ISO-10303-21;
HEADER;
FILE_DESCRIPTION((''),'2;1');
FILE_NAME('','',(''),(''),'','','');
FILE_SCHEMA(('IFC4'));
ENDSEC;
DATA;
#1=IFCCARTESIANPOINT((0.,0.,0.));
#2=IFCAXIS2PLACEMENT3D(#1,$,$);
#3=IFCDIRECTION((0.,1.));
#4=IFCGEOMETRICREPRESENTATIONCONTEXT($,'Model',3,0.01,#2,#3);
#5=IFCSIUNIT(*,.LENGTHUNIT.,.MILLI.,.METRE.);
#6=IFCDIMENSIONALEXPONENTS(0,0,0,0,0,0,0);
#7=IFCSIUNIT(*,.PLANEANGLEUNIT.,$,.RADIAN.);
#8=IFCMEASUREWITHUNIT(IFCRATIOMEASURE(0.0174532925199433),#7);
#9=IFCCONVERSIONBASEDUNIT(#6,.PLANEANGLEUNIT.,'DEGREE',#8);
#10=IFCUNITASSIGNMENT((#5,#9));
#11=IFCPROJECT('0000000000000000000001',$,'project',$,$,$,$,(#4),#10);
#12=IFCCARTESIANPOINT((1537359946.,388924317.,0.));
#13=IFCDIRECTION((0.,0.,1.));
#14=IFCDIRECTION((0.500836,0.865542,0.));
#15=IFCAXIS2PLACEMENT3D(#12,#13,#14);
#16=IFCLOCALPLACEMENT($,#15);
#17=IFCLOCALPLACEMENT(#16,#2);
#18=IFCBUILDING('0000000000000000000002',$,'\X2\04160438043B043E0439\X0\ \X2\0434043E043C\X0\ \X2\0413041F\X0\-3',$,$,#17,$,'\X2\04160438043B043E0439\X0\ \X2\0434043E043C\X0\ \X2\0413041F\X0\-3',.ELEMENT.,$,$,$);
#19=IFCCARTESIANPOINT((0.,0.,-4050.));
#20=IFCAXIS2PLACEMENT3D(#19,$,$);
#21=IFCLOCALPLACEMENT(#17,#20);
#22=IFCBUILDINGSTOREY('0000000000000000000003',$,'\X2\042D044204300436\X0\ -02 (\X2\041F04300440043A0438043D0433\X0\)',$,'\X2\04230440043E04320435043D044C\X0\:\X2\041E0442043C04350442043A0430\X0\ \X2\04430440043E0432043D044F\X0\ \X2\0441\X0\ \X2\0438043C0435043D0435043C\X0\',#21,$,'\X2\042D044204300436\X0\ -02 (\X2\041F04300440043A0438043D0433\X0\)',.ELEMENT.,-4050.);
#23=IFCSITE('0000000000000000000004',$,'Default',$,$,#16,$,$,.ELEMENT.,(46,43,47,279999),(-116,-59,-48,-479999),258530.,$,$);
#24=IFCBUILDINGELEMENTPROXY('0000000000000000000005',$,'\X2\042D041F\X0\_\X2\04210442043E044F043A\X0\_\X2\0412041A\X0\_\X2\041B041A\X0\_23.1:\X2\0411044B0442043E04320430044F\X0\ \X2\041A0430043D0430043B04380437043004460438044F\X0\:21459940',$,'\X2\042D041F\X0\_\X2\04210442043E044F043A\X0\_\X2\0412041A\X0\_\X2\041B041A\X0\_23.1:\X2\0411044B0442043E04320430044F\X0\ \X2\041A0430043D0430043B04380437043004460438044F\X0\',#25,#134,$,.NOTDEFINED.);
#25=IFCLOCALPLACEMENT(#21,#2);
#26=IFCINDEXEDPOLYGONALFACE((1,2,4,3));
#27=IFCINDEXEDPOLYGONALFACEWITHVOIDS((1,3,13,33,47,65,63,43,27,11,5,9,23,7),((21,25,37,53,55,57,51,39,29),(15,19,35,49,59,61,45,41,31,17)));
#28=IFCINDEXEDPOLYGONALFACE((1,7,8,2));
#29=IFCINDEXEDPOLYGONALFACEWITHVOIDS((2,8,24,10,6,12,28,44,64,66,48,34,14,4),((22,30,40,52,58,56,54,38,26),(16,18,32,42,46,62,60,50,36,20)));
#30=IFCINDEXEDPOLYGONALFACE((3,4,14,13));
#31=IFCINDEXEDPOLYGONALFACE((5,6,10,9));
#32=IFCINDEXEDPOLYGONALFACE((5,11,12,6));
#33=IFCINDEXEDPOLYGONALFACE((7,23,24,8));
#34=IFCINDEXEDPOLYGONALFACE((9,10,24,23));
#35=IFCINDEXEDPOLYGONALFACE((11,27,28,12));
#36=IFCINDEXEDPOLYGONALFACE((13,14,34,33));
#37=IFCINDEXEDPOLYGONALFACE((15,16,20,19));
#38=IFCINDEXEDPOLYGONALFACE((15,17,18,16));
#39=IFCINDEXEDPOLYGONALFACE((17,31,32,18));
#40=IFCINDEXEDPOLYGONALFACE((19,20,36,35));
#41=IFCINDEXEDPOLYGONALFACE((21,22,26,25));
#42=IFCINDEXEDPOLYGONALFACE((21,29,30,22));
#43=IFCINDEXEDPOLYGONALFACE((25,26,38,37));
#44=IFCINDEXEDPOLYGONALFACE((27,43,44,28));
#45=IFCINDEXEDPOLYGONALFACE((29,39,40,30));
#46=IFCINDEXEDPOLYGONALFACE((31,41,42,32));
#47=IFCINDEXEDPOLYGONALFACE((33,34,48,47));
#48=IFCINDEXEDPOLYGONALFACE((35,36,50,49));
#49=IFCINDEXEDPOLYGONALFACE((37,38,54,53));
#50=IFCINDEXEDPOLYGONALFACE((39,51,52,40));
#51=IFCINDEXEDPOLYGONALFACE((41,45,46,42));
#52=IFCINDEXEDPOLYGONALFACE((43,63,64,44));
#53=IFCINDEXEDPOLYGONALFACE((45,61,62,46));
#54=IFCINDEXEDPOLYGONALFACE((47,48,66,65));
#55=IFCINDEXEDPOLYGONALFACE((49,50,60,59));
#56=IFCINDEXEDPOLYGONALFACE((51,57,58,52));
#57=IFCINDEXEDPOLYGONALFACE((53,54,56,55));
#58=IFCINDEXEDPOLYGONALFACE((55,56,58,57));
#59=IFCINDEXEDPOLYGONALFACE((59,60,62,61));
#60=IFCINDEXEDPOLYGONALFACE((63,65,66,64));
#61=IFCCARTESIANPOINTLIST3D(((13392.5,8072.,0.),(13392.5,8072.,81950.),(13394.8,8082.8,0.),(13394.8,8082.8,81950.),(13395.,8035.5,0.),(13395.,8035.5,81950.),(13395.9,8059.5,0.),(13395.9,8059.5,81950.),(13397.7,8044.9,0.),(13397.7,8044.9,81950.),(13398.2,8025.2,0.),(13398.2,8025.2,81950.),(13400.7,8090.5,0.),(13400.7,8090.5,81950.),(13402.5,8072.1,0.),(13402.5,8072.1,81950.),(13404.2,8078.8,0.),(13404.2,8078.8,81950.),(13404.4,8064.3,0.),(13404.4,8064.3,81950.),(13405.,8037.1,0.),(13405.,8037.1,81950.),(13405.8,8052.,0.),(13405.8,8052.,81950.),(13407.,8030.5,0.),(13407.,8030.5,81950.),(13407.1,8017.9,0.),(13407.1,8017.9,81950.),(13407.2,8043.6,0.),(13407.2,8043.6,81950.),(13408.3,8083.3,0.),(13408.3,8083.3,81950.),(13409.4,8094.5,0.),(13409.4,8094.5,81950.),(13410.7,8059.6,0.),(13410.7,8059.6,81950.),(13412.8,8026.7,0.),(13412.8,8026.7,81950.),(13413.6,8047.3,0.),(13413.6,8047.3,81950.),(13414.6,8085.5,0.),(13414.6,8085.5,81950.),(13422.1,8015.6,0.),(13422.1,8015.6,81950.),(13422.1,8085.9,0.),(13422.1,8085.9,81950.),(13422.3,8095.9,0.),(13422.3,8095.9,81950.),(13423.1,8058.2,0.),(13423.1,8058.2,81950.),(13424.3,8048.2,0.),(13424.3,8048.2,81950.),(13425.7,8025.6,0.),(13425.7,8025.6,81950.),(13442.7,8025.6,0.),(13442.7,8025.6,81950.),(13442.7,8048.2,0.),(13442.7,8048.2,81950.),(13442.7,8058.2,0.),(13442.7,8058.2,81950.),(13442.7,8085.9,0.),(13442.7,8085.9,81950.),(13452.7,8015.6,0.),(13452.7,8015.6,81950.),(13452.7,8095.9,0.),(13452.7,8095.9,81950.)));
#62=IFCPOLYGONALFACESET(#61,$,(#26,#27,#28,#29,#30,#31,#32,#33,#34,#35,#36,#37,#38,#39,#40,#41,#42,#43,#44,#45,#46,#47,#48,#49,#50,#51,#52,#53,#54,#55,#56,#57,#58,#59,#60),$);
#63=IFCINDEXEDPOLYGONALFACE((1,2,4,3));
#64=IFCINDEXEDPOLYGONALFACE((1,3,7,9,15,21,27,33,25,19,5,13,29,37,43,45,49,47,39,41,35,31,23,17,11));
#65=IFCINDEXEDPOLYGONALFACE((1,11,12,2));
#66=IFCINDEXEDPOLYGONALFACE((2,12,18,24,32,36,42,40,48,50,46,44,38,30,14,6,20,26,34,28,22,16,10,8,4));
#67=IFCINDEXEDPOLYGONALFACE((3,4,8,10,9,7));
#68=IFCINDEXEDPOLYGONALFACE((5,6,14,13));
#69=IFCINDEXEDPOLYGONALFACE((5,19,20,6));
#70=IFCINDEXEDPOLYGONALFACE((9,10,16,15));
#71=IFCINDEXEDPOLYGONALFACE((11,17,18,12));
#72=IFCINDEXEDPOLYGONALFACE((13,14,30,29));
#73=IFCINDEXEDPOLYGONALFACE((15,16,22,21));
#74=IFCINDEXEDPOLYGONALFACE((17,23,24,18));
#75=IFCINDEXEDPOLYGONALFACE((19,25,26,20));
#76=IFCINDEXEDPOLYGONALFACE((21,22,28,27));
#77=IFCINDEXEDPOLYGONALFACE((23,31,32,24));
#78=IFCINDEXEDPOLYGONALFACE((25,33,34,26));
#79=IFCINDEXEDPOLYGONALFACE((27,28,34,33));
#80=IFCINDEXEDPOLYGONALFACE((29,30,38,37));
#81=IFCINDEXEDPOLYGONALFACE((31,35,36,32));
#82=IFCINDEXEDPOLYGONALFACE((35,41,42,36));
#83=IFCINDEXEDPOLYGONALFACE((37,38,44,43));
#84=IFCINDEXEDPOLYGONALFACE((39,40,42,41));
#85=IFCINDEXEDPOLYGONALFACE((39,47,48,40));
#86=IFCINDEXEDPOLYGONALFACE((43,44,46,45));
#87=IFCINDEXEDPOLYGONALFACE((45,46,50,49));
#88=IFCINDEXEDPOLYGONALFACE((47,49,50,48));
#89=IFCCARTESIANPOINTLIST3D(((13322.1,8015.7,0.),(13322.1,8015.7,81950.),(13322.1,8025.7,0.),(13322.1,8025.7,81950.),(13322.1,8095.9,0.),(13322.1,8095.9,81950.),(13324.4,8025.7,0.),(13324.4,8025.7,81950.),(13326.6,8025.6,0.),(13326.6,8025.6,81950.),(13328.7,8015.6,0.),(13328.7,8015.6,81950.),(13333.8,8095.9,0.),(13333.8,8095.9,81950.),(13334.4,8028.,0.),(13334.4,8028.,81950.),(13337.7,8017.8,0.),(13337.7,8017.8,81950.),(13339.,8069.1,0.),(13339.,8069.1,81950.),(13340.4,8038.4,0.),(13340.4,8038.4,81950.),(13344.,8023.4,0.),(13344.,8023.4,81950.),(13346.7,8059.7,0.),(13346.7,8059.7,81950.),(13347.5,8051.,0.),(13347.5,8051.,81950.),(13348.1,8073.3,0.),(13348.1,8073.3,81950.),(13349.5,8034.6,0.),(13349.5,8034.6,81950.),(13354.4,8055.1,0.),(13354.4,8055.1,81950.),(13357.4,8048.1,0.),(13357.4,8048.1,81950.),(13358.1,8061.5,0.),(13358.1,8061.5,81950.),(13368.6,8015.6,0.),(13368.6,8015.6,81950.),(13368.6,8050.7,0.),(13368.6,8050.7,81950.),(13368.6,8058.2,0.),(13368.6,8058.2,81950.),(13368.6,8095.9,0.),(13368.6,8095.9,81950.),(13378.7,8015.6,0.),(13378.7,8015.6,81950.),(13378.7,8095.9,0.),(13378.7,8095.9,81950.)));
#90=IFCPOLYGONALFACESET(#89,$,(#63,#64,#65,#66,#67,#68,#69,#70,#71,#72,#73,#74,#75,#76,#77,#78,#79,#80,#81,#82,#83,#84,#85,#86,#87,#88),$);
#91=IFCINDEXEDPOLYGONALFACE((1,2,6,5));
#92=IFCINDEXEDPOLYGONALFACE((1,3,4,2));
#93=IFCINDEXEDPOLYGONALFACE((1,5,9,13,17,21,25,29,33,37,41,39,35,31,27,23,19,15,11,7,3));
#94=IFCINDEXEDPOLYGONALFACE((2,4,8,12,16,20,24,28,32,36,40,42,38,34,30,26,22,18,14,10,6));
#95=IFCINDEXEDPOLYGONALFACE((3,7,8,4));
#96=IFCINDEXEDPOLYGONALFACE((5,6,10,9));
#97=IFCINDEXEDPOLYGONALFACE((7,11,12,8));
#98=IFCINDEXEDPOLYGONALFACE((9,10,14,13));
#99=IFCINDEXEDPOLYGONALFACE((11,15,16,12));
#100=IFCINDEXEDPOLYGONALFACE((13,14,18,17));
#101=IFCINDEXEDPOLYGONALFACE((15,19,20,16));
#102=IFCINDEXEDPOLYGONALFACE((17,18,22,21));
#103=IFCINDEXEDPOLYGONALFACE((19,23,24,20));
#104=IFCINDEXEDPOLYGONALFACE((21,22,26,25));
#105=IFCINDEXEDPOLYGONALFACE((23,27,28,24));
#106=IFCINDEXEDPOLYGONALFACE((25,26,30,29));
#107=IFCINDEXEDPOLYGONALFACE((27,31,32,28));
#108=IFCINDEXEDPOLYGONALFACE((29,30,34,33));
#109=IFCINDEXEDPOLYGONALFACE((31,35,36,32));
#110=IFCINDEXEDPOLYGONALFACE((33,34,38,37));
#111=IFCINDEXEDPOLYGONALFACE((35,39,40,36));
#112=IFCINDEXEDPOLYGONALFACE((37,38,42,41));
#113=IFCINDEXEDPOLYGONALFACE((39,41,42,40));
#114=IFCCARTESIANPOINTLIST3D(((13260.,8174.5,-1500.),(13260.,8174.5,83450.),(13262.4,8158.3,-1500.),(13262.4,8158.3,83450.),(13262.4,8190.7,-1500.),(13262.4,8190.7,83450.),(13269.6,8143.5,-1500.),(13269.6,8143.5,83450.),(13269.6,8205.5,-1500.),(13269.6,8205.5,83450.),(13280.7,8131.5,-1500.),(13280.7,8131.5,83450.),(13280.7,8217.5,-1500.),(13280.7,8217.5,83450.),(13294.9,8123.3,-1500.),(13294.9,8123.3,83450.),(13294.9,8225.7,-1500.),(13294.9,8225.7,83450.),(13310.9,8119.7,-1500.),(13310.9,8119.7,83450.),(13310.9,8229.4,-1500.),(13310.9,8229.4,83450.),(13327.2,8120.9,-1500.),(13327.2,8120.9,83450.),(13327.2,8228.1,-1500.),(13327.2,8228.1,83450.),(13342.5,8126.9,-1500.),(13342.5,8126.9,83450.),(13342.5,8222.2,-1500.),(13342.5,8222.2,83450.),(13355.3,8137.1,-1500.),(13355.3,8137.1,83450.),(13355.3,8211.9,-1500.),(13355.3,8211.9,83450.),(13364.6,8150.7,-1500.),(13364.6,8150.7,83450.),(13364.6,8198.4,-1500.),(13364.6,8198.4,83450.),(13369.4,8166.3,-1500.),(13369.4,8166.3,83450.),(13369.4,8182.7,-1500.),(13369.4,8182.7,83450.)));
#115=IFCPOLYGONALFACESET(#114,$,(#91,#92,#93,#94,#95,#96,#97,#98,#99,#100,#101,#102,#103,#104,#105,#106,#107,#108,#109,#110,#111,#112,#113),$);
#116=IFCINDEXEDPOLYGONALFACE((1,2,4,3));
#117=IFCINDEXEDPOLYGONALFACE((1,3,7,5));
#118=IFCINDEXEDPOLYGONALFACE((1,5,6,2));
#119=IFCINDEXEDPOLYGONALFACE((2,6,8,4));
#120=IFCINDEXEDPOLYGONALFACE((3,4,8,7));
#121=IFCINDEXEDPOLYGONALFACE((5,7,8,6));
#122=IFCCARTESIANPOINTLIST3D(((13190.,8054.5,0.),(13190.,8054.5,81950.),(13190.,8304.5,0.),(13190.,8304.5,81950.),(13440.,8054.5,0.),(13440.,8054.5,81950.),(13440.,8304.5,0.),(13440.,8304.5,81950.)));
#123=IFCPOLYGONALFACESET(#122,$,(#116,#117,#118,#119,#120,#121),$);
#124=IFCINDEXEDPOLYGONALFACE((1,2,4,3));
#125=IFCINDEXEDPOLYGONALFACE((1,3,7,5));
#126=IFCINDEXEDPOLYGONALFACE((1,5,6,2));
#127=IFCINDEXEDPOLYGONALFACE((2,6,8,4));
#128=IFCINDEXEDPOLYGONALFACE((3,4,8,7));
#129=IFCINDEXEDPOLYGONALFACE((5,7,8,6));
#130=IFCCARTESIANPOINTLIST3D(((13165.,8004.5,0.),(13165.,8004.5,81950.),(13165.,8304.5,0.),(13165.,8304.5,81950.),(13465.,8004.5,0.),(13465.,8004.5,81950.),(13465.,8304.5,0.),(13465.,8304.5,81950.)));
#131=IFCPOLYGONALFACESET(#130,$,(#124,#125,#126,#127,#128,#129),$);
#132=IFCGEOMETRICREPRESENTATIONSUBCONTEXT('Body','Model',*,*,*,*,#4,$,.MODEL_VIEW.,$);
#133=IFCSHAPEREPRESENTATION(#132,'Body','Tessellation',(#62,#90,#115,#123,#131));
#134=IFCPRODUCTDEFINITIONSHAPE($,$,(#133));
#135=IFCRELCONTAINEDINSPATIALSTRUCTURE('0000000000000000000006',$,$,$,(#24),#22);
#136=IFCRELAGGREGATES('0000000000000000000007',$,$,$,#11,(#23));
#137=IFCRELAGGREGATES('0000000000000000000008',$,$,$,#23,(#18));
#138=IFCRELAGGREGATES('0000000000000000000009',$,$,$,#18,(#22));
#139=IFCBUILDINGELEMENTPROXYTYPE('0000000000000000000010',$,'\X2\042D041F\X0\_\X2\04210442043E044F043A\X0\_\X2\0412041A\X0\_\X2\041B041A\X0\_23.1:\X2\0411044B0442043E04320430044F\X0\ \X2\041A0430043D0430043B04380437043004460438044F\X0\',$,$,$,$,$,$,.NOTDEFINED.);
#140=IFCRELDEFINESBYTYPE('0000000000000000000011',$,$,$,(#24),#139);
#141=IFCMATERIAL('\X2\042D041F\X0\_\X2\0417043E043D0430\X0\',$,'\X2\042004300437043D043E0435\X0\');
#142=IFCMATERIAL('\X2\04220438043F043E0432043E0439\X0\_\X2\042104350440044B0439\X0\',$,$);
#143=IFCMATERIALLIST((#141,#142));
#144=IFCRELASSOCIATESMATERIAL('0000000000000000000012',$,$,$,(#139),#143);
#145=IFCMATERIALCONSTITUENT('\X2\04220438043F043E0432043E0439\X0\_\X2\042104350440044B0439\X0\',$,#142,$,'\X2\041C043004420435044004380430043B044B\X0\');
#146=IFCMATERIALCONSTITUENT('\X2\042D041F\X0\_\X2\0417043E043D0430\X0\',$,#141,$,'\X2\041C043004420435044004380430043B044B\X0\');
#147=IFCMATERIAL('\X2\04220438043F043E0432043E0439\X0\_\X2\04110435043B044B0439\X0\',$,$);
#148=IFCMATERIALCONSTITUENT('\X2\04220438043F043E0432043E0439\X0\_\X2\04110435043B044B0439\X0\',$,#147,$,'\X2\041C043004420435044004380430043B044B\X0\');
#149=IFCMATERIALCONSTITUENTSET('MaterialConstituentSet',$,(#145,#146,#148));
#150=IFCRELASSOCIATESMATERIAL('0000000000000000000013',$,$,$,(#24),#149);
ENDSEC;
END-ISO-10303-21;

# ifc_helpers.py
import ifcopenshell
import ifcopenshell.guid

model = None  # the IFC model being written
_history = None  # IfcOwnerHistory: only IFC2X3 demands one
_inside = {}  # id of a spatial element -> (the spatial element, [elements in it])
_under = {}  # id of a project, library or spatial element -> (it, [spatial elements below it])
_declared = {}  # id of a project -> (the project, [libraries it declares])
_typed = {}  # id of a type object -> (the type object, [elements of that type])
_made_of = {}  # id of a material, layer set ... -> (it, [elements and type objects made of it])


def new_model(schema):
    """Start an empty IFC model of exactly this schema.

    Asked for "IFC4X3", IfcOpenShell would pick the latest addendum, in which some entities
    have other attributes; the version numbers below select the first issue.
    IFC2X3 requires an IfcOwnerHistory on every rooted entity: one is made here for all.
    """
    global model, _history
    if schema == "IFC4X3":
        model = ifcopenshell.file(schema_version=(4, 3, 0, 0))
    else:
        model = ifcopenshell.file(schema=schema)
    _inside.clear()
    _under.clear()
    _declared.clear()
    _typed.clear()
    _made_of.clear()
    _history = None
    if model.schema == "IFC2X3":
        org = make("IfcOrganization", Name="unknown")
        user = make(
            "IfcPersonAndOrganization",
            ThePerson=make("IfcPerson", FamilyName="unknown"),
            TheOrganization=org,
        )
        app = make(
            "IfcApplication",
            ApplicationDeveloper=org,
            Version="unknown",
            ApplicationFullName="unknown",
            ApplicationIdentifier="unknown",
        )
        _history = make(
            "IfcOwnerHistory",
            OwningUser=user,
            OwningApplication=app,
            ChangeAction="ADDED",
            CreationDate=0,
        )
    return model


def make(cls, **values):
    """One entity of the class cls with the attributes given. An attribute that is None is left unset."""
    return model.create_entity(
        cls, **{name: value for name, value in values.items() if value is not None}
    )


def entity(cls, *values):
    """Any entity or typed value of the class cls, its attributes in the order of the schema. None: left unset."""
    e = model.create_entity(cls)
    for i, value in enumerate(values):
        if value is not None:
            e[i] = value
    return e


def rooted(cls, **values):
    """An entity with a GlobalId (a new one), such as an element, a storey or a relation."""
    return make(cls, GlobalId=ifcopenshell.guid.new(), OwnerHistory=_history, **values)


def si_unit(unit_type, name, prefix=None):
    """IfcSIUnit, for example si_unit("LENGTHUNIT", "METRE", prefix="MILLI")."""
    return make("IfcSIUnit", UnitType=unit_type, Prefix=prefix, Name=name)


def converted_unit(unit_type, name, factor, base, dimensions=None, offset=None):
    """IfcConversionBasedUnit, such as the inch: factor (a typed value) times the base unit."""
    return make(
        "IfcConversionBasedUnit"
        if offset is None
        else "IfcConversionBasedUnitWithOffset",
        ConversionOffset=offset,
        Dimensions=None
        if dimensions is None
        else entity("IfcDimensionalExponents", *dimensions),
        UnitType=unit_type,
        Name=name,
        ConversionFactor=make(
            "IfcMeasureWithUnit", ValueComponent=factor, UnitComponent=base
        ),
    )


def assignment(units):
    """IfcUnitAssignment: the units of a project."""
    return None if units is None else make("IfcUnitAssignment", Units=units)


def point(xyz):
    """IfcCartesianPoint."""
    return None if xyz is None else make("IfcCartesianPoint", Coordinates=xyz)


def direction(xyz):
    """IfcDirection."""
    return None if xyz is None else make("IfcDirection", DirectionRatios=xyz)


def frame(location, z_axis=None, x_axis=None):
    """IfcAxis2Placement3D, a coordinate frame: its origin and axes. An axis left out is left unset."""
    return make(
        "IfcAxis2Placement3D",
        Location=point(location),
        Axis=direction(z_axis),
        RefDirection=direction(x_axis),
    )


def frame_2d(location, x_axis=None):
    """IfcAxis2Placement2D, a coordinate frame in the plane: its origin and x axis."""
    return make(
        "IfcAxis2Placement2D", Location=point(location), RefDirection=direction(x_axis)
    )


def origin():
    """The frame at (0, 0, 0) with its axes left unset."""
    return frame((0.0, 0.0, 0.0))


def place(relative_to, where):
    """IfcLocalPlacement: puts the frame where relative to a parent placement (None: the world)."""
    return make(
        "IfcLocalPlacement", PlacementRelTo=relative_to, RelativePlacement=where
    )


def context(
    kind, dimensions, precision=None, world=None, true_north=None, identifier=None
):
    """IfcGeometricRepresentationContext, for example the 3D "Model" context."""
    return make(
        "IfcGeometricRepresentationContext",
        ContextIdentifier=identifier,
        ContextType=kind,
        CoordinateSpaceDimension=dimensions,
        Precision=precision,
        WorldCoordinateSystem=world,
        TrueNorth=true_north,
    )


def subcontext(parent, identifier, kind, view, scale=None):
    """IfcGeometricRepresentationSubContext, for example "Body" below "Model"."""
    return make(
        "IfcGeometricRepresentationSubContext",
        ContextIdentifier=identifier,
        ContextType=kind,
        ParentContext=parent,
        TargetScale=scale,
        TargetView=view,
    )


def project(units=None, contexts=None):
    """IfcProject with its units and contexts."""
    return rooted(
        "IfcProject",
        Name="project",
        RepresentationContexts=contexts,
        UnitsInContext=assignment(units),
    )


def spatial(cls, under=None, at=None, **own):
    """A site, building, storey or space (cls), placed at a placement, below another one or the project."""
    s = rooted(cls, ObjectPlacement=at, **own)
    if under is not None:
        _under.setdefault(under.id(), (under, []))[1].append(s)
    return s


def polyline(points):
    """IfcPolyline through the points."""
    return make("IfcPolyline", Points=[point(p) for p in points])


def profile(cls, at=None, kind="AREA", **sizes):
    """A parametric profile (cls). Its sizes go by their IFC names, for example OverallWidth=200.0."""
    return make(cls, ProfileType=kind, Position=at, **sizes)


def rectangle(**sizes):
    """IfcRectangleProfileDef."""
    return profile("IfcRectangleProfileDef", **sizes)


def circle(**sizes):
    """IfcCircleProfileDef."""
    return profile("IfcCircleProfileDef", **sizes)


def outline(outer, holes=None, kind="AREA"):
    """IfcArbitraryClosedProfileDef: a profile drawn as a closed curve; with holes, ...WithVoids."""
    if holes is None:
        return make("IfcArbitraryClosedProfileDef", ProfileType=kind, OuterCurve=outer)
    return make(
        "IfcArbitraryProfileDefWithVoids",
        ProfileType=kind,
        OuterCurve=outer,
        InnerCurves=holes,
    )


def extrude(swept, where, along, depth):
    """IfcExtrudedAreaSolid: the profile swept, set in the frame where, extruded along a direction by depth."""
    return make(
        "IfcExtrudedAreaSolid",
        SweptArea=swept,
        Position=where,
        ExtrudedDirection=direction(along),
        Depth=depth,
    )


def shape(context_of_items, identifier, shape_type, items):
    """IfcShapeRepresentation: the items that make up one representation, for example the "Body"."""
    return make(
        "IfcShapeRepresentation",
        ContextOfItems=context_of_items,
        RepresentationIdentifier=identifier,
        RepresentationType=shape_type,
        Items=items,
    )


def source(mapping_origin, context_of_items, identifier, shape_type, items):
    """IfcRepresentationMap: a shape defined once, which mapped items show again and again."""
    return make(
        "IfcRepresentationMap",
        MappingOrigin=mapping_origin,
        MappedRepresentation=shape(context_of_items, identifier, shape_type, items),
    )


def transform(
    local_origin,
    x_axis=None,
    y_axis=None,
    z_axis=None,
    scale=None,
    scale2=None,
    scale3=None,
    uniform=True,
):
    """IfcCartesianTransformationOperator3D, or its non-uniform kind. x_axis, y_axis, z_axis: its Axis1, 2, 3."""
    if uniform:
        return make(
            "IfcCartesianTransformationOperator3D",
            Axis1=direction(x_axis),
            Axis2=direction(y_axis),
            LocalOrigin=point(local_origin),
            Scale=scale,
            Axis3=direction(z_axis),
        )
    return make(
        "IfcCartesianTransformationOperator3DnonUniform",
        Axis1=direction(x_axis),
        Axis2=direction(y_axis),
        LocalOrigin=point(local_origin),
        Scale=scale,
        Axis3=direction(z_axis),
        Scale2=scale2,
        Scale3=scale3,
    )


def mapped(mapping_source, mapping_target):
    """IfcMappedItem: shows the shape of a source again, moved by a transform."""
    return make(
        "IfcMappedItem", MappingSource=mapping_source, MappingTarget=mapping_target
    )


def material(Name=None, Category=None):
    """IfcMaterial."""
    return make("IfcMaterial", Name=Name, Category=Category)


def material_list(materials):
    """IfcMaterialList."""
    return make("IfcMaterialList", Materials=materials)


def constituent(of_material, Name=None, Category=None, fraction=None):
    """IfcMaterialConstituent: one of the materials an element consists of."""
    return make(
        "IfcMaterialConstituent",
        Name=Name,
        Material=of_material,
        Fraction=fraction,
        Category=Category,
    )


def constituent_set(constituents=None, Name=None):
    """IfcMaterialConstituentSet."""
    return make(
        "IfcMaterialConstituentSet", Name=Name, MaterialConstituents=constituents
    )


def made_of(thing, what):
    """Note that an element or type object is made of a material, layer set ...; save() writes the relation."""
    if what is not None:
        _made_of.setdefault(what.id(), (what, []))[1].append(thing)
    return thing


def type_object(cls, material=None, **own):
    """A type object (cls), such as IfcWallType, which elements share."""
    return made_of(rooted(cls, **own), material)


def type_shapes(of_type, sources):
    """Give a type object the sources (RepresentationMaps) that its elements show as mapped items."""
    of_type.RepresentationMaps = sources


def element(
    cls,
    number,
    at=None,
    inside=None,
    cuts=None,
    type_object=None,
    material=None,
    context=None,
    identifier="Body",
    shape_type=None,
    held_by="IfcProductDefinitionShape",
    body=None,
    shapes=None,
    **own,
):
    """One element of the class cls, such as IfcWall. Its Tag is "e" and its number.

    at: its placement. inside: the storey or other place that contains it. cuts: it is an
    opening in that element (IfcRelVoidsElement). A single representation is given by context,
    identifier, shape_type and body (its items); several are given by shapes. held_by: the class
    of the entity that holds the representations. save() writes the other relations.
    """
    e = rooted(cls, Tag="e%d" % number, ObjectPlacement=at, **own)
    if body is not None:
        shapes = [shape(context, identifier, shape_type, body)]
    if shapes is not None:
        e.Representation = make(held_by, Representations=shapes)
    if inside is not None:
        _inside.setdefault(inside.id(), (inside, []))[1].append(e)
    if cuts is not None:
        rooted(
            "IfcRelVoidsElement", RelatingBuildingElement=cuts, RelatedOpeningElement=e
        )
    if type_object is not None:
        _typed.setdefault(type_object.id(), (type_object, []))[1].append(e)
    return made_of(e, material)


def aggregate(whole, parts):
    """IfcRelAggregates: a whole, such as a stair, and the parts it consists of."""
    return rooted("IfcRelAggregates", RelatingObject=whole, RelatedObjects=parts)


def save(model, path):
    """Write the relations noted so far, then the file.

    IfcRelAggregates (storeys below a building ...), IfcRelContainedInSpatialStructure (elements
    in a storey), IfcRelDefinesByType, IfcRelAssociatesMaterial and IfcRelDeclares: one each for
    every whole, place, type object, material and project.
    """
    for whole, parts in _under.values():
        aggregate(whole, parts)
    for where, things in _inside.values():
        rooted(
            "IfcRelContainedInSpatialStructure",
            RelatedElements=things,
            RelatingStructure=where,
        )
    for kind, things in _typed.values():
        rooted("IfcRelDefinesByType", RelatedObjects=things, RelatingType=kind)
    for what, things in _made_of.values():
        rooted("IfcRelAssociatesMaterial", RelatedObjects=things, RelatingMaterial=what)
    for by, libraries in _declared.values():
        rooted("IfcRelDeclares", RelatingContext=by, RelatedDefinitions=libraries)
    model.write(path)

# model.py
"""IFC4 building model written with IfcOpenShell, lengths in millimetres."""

from ifc_helpers import new_model, entity, si_unit, converted_unit, direction, frame, frame_2d, origin, place, context, subcontext, project, spatial, polyline, rectangle, circle, outline, extrude, source, transform, mapped, material, material_list, constituent, constituent_set, type_object, type_shapes, element, save


model = new_model("IFC4")

# Units and contexts
model_context = context("Model", 3, precision=0.01, world=origin(), true_north=direction((0.0, 1.0)))
body_context = subcontext(model_context, "Body", "Model", "MODEL_VIEW")
ifc_project = project(units=[si_unit("LENGTHUNIT", "METRE", prefix="MILLI"), converted_unit("PLANEANGLEUNIT", "DEGREE", entity("IfcRatioMeasure", 0.0174532925199433), si_unit("PLANEANGLEUNIT", "RADIAN"), dimensions=[0, 0, 0, 0, 0, 0, 0])], contexts=[model_context])

# Site, building, storey
site_placement = place(None, frame((1537359946.0, 388924317.0, 0.0), z_axis=(0.0, 0.0, 1.0), x_axis=(0.500836, 0.865542, 0.0)))
site = spatial("IfcSite", under=ifc_project, at=site_placement, Name="Default", CompositionType="ELEMENT", RefLatitude=(46, 43, 47, 279999), RefLongitude=(-116, -59, -48, -479999), RefElevation=258530.0)
building_placement = place(site_placement, origin())
building = spatial("IfcBuilding", under=site, at=building_placement, Name="Жилой дом ГП-3", LongName="Жилой дом ГП-3", CompositionType="ELEMENT")
storey_placement = place(building_placement, frame((0.0, 0.0, -4050.0)))
storey = spatial("IfcBuildingStorey", under=building, at=storey_placement, Name="Этаж -02 (Паркинг)", ObjectType="Уровень:Отметка уровня с именем", LongName="Этаж -02 (Паркинг)", CompositionType="ELEMENT", Elevation=-4050.0)

# Building element proxy
ifc_material_1 = material(Name="Типовой_Серый")
ifc_constituent_1 = constituent(ifc_material_1, Name="Типовой_Серый", Category="Материалы")
ifc_material_2 = material(Name="ЭП_Зона", Category="Разное")
ifc_constituent_2 = constituent(ifc_material_2, Name="ЭП_Зона", Category="Материалы")
ifc_material_3 = material(Name="Типовой_Белый")
ifc_constituent_3 = constituent(ifc_material_3, Name="Типовой_Белый", Category="Материалы")
ifc_constituent_set_1 = constituent_set(constituents=[ifc_constituent_1, ifc_constituent_2, ifc_constituent_3], Name="MaterialConstituentSet")
ifc_material_list_1 = material_list([ifc_material_2, ifc_material_1])
building_element_proxy_type_1 = type_object("IfcBuildingElementProxyType", Name="ЭП_Стояк_ВК_ЛК_23.1:Бытовая Канализация", PredefinedType="NOTDEFINED", material=ifc_material_list_1)
shared_shape_1 = source(origin(), body_context, "Body", "SweptSolid", [
    extrude(outline(polyline([(-42.2, -39.0), (-11.8, -39.0), (1.1, -37.6), (9.8, -33.5), (15.7, -25.8), (18.0, -15.0), (14.6, -2.5), (4.7, 5.0), (12.8, 12.1), (15.5, 21.5), (12.3, 31.8), (3.4, 39.0), (-11.6, 41.4), (-42.2, 41.4), (-42.2, -39.0)]), holes=[polyline([(-32.2, 8.8), (-32.2, 31.4), (-15.2, 31.4), (-2.3, 30.3), (3.5, 26.4), (5.5, 19.9), (3.3, 13.3), (-3.1, 9.6), (-13.9, 8.8), (-32.2, 8.8)]), polyline([(-32.2, -28.9), (-32.2, -1.3), (-12.6, -1.3), (-0.2, -2.6), (6.1, -7.3), (8.0, -15.1), (6.3, -21.9), (2.2, -26.3), (-4.1, -28.5), (-11.6, -28.9), (-32.2, -28.9)])]), frame((54.5, -52.4, -4050.0)), (0.0, 0.0, 1.0), 81950.0),
    extrude(outline(polyline([(-32.1, -31.9), (48.3, -31.9), (48.3, -21.8), (10.6, -21.8), (13.8, -11.4), (25.6, -1.3), (48.3, 13.0), (48.3, 24.6), (21.4, 7.7), (12.0, 0.1), (7.4, -7.7), (3.3, -0.7), (-9.3, 6.4), (-19.7, 12.3), (-22.1, 20.2), (-22.0, 22.4), (-22.0, 24.6), (-32.0, 24.6), (-32.1, 18.0), (-29.9, 9.0), (-24.3, 2.8), (-13.1, -2.8), (0.4, -10.6), (3.0, -21.8), (-32.1, -21.8), (-32.1, -31.9)])), frame((118.2, -43.1, -4050.0), z_axis=(0.0, 0.0, 1.0), x_axis=(0.0, -1.0, 0.0)), (0.0, 0.0, 1.0), 81950.0),
    extrude(circle(Radius=55.0, at=frame_2d((0.0, 0.0), x_axis=(1.0, 0.0))), frame((150.0, -170.0, -5550.0)), (0.0, 0.0, 1.0), 84950.0),
    extrude(rectangle(XDim=250.0, YDim=250.0, at=frame_2d((0.0, 0.0), x_axis=(1.0, 0.0))), frame((150.0, -175.0, -4050.0)), (0.0, 0.0, 1.0), 81950.0),
    extrude(rectangle(XDim=300.0, YDim=300.0, at=frame_2d((0.0, 0.0), x_axis=(1.0, 0.0))), frame((150.0, -150.0, -4050.0)), (0.0, 0.0, 1.0), 81950.0),
])
type_shapes(building_element_proxy_type_1, [shared_shape_1])
proxy_1_placement = place(storey_placement, frame((13465.0, 8004.5, 4050.0), z_axis=(0.0, 0.0, 1.0), x_axis=(-1.0, 0.0, 0.0)))
element("IfcBuildingElementProxy", 1, at=proxy_1_placement, inside=storey, type_object=building_element_proxy_type_1, material=ifc_constituent_set_1, Name="ЭП_Стояк_ВК_ЛК_23.1:Бытовая Канализация:21459940", ObjectType="ЭП_Стояк_ВК_ЛК_23.1:Бытовая Канализация", PredefinedType="NOTDEFINED", context=body_context, shape_type="MappedRepresentation", body=[
    mapped(shared_shape_1, transform((0.0, 0.0, 0.0), scale=1.0)),
])

save(model, "model.ifc")
